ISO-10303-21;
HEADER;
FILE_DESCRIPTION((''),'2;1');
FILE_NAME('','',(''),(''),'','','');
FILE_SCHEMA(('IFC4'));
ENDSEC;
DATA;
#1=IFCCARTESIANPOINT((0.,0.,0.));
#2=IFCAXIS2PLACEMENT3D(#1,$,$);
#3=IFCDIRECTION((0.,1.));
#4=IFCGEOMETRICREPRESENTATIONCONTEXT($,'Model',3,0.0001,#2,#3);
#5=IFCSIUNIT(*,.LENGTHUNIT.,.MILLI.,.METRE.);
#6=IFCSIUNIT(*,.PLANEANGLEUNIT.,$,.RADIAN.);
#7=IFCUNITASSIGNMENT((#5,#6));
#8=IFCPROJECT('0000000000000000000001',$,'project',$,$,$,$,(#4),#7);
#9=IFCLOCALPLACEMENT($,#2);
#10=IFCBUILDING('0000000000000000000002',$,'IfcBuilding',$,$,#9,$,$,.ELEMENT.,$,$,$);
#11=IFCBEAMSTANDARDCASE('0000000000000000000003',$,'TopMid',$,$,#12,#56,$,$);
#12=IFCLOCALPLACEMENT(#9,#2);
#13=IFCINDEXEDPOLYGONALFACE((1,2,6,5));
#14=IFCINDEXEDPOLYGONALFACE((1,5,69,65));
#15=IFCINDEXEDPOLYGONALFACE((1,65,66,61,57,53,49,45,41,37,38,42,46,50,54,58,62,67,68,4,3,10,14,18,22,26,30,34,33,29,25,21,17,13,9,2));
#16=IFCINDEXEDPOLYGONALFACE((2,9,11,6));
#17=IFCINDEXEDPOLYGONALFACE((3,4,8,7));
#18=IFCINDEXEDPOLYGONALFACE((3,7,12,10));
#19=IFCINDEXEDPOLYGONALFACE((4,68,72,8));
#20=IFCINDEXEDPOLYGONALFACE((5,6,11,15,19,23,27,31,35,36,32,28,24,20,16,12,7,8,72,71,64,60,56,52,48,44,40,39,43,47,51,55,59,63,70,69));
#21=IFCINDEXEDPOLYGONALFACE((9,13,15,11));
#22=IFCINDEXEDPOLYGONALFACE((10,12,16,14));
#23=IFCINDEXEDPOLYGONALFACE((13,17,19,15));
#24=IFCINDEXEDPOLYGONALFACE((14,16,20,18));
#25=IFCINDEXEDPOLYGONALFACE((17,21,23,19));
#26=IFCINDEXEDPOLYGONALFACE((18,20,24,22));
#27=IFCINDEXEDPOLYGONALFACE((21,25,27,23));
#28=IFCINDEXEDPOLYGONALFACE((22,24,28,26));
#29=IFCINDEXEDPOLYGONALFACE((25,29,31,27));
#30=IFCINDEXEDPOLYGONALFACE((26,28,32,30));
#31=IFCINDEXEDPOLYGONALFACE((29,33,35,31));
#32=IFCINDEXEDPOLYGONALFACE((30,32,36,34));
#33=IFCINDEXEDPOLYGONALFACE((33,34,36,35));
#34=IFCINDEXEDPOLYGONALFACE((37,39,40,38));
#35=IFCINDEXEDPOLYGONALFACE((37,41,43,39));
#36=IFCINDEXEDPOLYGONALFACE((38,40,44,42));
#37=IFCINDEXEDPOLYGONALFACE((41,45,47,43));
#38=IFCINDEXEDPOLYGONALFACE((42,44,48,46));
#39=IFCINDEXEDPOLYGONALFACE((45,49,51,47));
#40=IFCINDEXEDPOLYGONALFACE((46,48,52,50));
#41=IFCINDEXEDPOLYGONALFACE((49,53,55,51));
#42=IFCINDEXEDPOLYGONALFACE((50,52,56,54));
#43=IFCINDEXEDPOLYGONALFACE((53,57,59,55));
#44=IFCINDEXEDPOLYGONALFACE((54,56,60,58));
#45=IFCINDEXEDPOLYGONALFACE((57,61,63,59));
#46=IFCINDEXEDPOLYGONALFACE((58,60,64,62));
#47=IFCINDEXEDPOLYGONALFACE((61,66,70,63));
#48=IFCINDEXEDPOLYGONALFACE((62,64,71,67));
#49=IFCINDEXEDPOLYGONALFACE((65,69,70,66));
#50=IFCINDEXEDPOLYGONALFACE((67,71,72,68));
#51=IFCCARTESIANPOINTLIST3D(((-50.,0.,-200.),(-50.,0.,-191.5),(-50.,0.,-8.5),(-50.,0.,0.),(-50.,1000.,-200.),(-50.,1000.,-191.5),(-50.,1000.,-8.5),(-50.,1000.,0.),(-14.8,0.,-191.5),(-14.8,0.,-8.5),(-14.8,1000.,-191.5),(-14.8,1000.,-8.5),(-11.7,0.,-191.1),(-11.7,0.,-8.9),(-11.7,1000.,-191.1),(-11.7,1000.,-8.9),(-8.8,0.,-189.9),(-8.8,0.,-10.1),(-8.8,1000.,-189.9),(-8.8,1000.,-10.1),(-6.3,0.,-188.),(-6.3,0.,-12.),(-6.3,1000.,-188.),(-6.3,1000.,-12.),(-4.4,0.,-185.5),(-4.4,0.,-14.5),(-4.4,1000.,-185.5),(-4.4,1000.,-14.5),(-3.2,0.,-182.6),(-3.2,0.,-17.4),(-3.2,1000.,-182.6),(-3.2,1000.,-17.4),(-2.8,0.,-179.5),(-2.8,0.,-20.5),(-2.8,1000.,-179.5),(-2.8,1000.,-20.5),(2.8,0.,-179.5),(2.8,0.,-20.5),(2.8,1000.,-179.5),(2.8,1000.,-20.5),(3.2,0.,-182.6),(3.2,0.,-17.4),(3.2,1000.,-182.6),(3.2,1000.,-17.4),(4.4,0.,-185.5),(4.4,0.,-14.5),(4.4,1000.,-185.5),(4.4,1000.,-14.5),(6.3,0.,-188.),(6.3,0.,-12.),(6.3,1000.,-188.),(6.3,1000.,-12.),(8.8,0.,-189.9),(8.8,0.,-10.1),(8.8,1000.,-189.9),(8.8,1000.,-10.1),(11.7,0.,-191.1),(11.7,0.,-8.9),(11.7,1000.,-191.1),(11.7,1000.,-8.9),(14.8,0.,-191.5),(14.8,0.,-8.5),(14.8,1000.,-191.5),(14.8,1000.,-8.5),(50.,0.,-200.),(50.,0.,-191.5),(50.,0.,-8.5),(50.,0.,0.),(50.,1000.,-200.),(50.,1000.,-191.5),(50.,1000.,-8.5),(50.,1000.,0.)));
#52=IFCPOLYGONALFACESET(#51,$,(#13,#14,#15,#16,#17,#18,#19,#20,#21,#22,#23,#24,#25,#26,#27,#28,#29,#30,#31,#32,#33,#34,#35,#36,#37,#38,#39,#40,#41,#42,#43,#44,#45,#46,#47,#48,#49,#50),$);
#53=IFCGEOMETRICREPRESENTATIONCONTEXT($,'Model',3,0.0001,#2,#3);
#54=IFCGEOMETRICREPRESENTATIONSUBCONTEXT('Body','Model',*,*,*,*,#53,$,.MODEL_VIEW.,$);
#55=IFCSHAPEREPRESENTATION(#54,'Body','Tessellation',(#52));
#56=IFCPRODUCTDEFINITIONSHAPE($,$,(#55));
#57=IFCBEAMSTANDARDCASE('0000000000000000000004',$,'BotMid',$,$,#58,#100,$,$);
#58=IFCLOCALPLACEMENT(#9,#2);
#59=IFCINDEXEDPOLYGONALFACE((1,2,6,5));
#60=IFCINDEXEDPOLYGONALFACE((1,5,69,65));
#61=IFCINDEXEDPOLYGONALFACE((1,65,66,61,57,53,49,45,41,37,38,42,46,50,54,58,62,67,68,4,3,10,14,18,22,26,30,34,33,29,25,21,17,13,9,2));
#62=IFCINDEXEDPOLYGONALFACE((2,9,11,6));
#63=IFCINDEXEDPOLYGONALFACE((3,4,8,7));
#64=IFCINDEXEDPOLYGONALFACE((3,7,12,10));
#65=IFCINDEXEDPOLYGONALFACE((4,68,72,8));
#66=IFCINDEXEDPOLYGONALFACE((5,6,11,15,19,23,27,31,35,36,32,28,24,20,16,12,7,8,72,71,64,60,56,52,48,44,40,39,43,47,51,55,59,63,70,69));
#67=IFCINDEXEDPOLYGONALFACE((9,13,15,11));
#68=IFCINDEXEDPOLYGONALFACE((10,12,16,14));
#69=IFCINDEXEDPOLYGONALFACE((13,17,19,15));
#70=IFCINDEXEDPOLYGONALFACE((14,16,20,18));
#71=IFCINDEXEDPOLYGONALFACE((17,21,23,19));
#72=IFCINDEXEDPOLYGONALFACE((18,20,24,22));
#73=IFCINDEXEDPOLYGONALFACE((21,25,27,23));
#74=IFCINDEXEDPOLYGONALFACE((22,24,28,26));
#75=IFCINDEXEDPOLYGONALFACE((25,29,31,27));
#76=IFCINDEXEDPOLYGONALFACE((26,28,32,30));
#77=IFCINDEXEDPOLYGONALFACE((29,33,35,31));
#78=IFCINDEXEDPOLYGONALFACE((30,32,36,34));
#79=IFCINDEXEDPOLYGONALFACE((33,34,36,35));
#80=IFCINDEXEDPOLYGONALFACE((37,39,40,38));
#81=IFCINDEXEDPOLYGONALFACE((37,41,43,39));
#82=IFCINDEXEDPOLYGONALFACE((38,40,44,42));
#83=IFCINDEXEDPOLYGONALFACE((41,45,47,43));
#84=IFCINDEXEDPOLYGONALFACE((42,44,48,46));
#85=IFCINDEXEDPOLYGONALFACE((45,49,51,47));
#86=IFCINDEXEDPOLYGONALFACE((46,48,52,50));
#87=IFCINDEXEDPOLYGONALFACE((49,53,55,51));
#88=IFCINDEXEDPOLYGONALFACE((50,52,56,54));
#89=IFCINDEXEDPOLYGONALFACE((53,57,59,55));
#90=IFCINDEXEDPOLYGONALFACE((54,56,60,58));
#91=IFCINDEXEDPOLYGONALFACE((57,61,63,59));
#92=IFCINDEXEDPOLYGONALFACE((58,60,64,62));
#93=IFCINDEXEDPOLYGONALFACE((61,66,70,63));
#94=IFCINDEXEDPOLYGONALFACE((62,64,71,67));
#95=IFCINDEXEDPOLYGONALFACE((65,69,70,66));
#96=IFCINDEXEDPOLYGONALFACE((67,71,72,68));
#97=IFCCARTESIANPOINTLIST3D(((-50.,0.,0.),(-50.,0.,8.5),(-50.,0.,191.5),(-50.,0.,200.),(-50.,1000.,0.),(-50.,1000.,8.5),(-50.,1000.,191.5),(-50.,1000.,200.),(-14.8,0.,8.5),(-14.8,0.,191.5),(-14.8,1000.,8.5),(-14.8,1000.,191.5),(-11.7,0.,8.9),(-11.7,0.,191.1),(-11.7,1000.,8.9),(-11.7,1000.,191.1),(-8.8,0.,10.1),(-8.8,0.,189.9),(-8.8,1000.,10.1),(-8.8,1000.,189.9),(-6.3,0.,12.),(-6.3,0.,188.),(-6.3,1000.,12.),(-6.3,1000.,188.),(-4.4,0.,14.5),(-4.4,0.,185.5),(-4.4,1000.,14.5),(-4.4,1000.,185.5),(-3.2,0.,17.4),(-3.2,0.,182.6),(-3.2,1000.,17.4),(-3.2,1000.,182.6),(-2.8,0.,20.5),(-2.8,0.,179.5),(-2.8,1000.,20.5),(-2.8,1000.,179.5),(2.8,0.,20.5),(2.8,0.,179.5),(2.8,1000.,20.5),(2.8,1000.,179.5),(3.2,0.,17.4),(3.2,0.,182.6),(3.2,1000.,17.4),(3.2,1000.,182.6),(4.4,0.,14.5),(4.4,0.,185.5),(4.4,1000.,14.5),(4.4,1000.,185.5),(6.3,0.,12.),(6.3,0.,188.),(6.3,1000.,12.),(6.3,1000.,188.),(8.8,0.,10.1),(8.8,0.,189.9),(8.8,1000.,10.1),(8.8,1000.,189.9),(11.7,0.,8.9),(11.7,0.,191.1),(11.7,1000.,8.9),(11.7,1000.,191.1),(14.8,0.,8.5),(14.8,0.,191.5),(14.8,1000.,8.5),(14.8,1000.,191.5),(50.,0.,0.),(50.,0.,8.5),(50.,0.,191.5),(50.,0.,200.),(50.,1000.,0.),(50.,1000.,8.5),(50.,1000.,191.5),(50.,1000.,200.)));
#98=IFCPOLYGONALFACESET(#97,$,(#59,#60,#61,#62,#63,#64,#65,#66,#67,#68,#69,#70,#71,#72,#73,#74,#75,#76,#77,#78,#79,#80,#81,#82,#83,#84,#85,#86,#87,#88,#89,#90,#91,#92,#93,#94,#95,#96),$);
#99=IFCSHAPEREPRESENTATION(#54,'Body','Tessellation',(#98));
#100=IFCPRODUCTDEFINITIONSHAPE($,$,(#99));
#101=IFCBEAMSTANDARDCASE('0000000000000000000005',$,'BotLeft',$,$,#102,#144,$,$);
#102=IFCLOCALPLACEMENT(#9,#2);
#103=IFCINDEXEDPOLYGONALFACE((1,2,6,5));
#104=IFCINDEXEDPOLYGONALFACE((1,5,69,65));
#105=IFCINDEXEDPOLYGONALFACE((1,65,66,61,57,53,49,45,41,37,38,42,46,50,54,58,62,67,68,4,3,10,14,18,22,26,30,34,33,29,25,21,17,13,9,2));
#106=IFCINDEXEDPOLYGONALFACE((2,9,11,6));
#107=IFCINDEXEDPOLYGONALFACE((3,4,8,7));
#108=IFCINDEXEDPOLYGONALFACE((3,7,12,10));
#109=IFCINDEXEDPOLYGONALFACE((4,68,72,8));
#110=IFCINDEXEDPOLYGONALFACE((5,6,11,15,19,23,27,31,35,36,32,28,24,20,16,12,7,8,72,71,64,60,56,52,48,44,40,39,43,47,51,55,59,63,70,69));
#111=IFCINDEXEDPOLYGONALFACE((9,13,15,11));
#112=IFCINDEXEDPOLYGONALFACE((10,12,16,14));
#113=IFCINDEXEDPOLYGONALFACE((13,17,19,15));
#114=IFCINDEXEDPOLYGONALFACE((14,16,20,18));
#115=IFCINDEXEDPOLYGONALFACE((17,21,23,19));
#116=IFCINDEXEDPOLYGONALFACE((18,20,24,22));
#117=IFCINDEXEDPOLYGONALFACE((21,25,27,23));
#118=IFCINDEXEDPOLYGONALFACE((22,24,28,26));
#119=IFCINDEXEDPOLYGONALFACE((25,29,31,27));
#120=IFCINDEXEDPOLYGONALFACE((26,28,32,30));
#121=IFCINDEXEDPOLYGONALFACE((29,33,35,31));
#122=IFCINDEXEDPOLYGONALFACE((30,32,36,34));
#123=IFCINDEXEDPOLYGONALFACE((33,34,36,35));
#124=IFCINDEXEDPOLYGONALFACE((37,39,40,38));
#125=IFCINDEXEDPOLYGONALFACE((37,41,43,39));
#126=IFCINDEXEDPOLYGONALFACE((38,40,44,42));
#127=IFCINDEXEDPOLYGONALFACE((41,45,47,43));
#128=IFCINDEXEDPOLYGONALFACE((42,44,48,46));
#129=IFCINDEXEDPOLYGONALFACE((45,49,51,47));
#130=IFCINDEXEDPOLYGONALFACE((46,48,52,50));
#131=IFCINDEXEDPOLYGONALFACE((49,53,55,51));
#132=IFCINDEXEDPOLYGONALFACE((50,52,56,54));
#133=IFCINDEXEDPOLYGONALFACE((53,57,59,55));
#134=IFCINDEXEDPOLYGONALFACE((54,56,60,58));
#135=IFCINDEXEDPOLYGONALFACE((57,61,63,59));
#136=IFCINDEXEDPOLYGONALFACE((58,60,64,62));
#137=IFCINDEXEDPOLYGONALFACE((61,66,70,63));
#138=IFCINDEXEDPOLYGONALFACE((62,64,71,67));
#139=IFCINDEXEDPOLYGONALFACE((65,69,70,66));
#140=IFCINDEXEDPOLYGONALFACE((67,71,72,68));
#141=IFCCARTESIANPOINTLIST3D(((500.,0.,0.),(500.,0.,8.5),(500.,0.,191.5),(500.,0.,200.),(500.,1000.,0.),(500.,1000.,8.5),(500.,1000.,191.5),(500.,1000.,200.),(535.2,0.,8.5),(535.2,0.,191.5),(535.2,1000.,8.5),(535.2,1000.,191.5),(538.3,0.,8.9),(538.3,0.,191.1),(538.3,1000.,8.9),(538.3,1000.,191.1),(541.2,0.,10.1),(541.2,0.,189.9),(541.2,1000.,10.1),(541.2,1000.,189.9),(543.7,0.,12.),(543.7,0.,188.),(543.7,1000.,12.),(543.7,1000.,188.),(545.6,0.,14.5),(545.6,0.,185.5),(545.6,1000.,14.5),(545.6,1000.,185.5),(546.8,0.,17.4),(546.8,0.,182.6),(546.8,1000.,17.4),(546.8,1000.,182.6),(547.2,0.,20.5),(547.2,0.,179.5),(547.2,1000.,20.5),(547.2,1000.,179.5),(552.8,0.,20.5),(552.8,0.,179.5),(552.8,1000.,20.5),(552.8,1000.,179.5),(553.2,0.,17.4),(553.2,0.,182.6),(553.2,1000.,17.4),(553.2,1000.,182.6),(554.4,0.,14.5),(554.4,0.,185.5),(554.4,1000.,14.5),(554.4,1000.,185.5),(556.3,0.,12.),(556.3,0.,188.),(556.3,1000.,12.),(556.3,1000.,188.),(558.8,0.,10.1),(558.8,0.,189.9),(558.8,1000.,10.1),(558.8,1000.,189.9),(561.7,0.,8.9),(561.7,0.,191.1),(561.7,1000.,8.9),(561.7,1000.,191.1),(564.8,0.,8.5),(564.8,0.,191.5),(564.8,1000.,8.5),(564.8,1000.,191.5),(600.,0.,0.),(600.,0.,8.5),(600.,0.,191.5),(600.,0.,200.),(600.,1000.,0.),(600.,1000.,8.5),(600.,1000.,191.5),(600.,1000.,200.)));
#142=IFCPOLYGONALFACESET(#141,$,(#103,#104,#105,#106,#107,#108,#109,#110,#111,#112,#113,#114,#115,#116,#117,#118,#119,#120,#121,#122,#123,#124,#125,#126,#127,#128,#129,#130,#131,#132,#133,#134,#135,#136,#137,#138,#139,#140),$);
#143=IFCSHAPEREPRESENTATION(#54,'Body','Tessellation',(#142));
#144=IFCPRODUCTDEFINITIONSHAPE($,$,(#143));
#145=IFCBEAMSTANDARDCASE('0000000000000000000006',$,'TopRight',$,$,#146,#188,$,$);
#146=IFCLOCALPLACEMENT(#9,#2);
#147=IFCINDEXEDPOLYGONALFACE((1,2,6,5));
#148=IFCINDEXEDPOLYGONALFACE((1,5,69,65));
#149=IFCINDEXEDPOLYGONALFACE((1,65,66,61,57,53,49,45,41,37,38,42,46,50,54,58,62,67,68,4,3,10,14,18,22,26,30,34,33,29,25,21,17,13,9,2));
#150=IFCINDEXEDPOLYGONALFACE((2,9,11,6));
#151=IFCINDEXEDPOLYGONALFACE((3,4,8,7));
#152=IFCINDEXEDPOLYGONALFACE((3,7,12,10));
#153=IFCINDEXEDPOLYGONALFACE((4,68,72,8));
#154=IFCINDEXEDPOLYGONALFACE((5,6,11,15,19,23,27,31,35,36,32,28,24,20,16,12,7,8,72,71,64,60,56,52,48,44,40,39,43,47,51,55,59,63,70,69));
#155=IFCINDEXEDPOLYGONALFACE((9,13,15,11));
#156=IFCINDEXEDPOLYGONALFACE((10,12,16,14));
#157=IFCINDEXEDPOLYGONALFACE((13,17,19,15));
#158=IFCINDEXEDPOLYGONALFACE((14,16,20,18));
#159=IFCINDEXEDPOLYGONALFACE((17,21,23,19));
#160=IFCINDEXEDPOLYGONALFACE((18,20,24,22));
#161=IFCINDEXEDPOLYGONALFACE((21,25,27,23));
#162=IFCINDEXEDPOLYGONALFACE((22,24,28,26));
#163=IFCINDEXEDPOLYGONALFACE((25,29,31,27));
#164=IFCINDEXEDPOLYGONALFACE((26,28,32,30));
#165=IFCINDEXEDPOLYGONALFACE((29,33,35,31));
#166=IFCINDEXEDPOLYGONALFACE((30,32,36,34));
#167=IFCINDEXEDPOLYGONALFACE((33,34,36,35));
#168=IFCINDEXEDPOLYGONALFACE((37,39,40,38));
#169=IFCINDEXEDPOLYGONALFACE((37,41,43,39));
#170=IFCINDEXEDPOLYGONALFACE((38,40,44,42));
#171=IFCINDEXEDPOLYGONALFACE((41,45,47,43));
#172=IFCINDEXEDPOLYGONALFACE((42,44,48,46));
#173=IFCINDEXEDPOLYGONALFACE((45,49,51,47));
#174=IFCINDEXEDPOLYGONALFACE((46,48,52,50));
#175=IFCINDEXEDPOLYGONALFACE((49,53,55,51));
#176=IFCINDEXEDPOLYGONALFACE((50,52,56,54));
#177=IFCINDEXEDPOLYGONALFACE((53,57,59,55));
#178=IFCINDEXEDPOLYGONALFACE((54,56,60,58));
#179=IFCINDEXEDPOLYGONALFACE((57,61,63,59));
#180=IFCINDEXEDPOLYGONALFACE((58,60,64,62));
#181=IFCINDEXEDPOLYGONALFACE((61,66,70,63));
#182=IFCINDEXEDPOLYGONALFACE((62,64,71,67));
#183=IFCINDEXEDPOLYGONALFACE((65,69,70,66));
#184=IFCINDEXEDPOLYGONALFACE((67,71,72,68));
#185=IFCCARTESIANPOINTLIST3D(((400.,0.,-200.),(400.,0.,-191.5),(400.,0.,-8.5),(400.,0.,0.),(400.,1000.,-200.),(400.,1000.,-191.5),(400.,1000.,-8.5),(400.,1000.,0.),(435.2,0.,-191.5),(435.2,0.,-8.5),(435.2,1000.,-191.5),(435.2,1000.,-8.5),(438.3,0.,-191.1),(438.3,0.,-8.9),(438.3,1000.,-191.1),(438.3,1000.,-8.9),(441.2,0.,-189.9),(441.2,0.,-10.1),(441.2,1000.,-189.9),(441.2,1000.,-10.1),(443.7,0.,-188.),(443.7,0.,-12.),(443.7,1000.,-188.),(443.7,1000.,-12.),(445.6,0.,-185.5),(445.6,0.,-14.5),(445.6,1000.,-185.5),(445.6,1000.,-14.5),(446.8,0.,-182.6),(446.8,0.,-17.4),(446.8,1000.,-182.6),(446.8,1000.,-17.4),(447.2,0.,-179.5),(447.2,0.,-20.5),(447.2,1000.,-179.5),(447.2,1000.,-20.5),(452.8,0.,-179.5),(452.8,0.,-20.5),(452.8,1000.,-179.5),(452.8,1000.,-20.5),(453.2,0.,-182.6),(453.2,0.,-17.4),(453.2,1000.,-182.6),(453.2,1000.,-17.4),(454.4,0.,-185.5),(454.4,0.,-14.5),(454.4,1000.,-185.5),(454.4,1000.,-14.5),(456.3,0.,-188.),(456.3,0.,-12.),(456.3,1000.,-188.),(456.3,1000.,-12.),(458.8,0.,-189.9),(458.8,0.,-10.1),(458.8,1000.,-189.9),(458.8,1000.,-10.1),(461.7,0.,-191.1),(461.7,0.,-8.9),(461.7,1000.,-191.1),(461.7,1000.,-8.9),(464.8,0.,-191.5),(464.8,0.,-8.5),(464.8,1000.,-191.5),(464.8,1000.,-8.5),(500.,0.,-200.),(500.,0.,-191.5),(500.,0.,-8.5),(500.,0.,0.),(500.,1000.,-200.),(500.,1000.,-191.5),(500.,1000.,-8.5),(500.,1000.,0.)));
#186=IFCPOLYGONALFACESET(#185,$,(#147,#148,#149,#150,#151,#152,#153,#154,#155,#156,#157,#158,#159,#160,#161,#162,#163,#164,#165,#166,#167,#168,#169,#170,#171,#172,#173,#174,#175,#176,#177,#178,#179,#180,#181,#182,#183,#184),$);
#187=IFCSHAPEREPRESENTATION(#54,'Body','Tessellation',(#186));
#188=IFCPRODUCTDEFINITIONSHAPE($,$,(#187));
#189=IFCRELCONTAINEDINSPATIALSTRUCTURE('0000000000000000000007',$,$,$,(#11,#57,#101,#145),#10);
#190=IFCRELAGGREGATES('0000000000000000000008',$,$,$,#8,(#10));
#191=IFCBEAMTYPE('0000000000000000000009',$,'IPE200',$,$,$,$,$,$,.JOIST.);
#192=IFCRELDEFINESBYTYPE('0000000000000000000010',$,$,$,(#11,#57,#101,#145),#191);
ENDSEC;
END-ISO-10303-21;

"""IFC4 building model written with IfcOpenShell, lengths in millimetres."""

from ifc_helpers import new_model, si_unit, direction, frame, origin, place, context, subcontext, project, spatial, i_section, extrude, type_object, element, save


model = new_model("IFC4")

# Units and contexts
model_context_1 = context("Model", 3, precision=0.0001, world=origin(), true_north=direction((0.0, 1.0)))
model_context_2 = context("Model", 3, precision=0.0001, world=origin(), true_north=direction((0.0, 1.0)))
body_context = subcontext(model_context_1, "Body", "Model", "MODEL_VIEW")
ifc_project = project(units=[si_unit("LENGTHUNIT", "METRE", prefix="MILLI"), si_unit("PLANEANGLEUNIT", "RADIAN")], contexts=[model_context_2])

# Building
building_placement = place(None, origin())
building = spatial("IfcBuilding", under=ifc_project, at=building_placement, Name="IfcBuilding", CompositionType="ELEMENT")

# Beams
beam_type = type_object("IfcBeamType", Name="IPE200", PredefinedType="JOIST")
beam_1_placement = place(None, frame((0.0, 0.0, 0.0), z_axis=(0.0, 1.0, 0.0), x_axis=(-1.0, 0.0, 0.0)))
element("IfcBeamStandardCase", 1, at=beam_1_placement, inside=building, type_object=beam_type, Name="TopMid", context=body_context, shape_type="SweptSolid", body=[
    extrude(i_section(OverallWidth=100.0, OverallDepth=200.0, WebThickness=5.6, FlangeThickness=8.5, FilletRadius=12.0), frame((0.0, -100.0, 0.0), z_axis=(0.0, 0.0, 1.0), x_axis=(1.0, 0.0, 0.0)), (0.0, 0.0, 1.0), 1000.0),
])
beam_2_placement = place(None, frame((0.0, 0.0, 0.0), z_axis=(0.0, 1.0, 0.0), x_axis=(-1.0, 0.0, 0.0)))
element("IfcBeamStandardCase", 2, at=beam_2_placement, inside=building, type_object=beam_type, Name="BotMid", context=body_context, shape_type="SweptSolid", body=[
    extrude(i_section(OverallWidth=100.0, OverallDepth=200.0, WebThickness=5.6, FlangeThickness=8.5, FilletRadius=12.0), frame((0.0, 100.0, 0.0), z_axis=(0.0, 0.0, 1.0), x_axis=(1.0, 0.0, 0.0)), (0.0, 0.0, 1.0), 1000.0),
])
beam_3_placement = place(None, frame((500.0, 0.0, 0.0), z_axis=(0.0, 1.0, 0.0), x_axis=(-1.0, 0.0, 0.0)))
element("IfcBeamStandardCase", 3, at=beam_3_placement, inside=building, type_object=beam_type, Name="BotLeft", context=body_context, shape_type="SweptSolid", body=[
    extrude(i_section(OverallWidth=100.0, OverallDepth=200.0, WebThickness=5.6, FlangeThickness=8.5, FilletRadius=12.0), frame((-50.0, 100.0, 0.0), z_axis=(0.0, 0.0, 1.0), x_axis=(1.0, 0.0, 0.0)), (0.0, 0.0, 1.0), 1000.0),
])
beam_4_placement = place(None, frame((500.0, 0.0, 0.0), z_axis=(0.0, 1.0, 0.0), x_axis=(-1.0, 0.0, 0.0)))
element("IfcBeamStandardCase", 4, at=beam_4_placement, inside=building, type_object=beam_type, Name="TopRight", context=body_context, shape_type="SweptSolid", body=[
    extrude(i_section(OverallWidth=100.0, OverallDepth=200.0, WebThickness=5.6, FlangeThickness=8.5, FilletRadius=12.0), frame((50.0, -100.0, 0.0), z_axis=(0.0, 0.0, 1.0), x_axis=(1.0, 0.0, 0.0)), (0.0, 0.0, 1.0), 1000.0),
])

save(model, "model.ifc")
